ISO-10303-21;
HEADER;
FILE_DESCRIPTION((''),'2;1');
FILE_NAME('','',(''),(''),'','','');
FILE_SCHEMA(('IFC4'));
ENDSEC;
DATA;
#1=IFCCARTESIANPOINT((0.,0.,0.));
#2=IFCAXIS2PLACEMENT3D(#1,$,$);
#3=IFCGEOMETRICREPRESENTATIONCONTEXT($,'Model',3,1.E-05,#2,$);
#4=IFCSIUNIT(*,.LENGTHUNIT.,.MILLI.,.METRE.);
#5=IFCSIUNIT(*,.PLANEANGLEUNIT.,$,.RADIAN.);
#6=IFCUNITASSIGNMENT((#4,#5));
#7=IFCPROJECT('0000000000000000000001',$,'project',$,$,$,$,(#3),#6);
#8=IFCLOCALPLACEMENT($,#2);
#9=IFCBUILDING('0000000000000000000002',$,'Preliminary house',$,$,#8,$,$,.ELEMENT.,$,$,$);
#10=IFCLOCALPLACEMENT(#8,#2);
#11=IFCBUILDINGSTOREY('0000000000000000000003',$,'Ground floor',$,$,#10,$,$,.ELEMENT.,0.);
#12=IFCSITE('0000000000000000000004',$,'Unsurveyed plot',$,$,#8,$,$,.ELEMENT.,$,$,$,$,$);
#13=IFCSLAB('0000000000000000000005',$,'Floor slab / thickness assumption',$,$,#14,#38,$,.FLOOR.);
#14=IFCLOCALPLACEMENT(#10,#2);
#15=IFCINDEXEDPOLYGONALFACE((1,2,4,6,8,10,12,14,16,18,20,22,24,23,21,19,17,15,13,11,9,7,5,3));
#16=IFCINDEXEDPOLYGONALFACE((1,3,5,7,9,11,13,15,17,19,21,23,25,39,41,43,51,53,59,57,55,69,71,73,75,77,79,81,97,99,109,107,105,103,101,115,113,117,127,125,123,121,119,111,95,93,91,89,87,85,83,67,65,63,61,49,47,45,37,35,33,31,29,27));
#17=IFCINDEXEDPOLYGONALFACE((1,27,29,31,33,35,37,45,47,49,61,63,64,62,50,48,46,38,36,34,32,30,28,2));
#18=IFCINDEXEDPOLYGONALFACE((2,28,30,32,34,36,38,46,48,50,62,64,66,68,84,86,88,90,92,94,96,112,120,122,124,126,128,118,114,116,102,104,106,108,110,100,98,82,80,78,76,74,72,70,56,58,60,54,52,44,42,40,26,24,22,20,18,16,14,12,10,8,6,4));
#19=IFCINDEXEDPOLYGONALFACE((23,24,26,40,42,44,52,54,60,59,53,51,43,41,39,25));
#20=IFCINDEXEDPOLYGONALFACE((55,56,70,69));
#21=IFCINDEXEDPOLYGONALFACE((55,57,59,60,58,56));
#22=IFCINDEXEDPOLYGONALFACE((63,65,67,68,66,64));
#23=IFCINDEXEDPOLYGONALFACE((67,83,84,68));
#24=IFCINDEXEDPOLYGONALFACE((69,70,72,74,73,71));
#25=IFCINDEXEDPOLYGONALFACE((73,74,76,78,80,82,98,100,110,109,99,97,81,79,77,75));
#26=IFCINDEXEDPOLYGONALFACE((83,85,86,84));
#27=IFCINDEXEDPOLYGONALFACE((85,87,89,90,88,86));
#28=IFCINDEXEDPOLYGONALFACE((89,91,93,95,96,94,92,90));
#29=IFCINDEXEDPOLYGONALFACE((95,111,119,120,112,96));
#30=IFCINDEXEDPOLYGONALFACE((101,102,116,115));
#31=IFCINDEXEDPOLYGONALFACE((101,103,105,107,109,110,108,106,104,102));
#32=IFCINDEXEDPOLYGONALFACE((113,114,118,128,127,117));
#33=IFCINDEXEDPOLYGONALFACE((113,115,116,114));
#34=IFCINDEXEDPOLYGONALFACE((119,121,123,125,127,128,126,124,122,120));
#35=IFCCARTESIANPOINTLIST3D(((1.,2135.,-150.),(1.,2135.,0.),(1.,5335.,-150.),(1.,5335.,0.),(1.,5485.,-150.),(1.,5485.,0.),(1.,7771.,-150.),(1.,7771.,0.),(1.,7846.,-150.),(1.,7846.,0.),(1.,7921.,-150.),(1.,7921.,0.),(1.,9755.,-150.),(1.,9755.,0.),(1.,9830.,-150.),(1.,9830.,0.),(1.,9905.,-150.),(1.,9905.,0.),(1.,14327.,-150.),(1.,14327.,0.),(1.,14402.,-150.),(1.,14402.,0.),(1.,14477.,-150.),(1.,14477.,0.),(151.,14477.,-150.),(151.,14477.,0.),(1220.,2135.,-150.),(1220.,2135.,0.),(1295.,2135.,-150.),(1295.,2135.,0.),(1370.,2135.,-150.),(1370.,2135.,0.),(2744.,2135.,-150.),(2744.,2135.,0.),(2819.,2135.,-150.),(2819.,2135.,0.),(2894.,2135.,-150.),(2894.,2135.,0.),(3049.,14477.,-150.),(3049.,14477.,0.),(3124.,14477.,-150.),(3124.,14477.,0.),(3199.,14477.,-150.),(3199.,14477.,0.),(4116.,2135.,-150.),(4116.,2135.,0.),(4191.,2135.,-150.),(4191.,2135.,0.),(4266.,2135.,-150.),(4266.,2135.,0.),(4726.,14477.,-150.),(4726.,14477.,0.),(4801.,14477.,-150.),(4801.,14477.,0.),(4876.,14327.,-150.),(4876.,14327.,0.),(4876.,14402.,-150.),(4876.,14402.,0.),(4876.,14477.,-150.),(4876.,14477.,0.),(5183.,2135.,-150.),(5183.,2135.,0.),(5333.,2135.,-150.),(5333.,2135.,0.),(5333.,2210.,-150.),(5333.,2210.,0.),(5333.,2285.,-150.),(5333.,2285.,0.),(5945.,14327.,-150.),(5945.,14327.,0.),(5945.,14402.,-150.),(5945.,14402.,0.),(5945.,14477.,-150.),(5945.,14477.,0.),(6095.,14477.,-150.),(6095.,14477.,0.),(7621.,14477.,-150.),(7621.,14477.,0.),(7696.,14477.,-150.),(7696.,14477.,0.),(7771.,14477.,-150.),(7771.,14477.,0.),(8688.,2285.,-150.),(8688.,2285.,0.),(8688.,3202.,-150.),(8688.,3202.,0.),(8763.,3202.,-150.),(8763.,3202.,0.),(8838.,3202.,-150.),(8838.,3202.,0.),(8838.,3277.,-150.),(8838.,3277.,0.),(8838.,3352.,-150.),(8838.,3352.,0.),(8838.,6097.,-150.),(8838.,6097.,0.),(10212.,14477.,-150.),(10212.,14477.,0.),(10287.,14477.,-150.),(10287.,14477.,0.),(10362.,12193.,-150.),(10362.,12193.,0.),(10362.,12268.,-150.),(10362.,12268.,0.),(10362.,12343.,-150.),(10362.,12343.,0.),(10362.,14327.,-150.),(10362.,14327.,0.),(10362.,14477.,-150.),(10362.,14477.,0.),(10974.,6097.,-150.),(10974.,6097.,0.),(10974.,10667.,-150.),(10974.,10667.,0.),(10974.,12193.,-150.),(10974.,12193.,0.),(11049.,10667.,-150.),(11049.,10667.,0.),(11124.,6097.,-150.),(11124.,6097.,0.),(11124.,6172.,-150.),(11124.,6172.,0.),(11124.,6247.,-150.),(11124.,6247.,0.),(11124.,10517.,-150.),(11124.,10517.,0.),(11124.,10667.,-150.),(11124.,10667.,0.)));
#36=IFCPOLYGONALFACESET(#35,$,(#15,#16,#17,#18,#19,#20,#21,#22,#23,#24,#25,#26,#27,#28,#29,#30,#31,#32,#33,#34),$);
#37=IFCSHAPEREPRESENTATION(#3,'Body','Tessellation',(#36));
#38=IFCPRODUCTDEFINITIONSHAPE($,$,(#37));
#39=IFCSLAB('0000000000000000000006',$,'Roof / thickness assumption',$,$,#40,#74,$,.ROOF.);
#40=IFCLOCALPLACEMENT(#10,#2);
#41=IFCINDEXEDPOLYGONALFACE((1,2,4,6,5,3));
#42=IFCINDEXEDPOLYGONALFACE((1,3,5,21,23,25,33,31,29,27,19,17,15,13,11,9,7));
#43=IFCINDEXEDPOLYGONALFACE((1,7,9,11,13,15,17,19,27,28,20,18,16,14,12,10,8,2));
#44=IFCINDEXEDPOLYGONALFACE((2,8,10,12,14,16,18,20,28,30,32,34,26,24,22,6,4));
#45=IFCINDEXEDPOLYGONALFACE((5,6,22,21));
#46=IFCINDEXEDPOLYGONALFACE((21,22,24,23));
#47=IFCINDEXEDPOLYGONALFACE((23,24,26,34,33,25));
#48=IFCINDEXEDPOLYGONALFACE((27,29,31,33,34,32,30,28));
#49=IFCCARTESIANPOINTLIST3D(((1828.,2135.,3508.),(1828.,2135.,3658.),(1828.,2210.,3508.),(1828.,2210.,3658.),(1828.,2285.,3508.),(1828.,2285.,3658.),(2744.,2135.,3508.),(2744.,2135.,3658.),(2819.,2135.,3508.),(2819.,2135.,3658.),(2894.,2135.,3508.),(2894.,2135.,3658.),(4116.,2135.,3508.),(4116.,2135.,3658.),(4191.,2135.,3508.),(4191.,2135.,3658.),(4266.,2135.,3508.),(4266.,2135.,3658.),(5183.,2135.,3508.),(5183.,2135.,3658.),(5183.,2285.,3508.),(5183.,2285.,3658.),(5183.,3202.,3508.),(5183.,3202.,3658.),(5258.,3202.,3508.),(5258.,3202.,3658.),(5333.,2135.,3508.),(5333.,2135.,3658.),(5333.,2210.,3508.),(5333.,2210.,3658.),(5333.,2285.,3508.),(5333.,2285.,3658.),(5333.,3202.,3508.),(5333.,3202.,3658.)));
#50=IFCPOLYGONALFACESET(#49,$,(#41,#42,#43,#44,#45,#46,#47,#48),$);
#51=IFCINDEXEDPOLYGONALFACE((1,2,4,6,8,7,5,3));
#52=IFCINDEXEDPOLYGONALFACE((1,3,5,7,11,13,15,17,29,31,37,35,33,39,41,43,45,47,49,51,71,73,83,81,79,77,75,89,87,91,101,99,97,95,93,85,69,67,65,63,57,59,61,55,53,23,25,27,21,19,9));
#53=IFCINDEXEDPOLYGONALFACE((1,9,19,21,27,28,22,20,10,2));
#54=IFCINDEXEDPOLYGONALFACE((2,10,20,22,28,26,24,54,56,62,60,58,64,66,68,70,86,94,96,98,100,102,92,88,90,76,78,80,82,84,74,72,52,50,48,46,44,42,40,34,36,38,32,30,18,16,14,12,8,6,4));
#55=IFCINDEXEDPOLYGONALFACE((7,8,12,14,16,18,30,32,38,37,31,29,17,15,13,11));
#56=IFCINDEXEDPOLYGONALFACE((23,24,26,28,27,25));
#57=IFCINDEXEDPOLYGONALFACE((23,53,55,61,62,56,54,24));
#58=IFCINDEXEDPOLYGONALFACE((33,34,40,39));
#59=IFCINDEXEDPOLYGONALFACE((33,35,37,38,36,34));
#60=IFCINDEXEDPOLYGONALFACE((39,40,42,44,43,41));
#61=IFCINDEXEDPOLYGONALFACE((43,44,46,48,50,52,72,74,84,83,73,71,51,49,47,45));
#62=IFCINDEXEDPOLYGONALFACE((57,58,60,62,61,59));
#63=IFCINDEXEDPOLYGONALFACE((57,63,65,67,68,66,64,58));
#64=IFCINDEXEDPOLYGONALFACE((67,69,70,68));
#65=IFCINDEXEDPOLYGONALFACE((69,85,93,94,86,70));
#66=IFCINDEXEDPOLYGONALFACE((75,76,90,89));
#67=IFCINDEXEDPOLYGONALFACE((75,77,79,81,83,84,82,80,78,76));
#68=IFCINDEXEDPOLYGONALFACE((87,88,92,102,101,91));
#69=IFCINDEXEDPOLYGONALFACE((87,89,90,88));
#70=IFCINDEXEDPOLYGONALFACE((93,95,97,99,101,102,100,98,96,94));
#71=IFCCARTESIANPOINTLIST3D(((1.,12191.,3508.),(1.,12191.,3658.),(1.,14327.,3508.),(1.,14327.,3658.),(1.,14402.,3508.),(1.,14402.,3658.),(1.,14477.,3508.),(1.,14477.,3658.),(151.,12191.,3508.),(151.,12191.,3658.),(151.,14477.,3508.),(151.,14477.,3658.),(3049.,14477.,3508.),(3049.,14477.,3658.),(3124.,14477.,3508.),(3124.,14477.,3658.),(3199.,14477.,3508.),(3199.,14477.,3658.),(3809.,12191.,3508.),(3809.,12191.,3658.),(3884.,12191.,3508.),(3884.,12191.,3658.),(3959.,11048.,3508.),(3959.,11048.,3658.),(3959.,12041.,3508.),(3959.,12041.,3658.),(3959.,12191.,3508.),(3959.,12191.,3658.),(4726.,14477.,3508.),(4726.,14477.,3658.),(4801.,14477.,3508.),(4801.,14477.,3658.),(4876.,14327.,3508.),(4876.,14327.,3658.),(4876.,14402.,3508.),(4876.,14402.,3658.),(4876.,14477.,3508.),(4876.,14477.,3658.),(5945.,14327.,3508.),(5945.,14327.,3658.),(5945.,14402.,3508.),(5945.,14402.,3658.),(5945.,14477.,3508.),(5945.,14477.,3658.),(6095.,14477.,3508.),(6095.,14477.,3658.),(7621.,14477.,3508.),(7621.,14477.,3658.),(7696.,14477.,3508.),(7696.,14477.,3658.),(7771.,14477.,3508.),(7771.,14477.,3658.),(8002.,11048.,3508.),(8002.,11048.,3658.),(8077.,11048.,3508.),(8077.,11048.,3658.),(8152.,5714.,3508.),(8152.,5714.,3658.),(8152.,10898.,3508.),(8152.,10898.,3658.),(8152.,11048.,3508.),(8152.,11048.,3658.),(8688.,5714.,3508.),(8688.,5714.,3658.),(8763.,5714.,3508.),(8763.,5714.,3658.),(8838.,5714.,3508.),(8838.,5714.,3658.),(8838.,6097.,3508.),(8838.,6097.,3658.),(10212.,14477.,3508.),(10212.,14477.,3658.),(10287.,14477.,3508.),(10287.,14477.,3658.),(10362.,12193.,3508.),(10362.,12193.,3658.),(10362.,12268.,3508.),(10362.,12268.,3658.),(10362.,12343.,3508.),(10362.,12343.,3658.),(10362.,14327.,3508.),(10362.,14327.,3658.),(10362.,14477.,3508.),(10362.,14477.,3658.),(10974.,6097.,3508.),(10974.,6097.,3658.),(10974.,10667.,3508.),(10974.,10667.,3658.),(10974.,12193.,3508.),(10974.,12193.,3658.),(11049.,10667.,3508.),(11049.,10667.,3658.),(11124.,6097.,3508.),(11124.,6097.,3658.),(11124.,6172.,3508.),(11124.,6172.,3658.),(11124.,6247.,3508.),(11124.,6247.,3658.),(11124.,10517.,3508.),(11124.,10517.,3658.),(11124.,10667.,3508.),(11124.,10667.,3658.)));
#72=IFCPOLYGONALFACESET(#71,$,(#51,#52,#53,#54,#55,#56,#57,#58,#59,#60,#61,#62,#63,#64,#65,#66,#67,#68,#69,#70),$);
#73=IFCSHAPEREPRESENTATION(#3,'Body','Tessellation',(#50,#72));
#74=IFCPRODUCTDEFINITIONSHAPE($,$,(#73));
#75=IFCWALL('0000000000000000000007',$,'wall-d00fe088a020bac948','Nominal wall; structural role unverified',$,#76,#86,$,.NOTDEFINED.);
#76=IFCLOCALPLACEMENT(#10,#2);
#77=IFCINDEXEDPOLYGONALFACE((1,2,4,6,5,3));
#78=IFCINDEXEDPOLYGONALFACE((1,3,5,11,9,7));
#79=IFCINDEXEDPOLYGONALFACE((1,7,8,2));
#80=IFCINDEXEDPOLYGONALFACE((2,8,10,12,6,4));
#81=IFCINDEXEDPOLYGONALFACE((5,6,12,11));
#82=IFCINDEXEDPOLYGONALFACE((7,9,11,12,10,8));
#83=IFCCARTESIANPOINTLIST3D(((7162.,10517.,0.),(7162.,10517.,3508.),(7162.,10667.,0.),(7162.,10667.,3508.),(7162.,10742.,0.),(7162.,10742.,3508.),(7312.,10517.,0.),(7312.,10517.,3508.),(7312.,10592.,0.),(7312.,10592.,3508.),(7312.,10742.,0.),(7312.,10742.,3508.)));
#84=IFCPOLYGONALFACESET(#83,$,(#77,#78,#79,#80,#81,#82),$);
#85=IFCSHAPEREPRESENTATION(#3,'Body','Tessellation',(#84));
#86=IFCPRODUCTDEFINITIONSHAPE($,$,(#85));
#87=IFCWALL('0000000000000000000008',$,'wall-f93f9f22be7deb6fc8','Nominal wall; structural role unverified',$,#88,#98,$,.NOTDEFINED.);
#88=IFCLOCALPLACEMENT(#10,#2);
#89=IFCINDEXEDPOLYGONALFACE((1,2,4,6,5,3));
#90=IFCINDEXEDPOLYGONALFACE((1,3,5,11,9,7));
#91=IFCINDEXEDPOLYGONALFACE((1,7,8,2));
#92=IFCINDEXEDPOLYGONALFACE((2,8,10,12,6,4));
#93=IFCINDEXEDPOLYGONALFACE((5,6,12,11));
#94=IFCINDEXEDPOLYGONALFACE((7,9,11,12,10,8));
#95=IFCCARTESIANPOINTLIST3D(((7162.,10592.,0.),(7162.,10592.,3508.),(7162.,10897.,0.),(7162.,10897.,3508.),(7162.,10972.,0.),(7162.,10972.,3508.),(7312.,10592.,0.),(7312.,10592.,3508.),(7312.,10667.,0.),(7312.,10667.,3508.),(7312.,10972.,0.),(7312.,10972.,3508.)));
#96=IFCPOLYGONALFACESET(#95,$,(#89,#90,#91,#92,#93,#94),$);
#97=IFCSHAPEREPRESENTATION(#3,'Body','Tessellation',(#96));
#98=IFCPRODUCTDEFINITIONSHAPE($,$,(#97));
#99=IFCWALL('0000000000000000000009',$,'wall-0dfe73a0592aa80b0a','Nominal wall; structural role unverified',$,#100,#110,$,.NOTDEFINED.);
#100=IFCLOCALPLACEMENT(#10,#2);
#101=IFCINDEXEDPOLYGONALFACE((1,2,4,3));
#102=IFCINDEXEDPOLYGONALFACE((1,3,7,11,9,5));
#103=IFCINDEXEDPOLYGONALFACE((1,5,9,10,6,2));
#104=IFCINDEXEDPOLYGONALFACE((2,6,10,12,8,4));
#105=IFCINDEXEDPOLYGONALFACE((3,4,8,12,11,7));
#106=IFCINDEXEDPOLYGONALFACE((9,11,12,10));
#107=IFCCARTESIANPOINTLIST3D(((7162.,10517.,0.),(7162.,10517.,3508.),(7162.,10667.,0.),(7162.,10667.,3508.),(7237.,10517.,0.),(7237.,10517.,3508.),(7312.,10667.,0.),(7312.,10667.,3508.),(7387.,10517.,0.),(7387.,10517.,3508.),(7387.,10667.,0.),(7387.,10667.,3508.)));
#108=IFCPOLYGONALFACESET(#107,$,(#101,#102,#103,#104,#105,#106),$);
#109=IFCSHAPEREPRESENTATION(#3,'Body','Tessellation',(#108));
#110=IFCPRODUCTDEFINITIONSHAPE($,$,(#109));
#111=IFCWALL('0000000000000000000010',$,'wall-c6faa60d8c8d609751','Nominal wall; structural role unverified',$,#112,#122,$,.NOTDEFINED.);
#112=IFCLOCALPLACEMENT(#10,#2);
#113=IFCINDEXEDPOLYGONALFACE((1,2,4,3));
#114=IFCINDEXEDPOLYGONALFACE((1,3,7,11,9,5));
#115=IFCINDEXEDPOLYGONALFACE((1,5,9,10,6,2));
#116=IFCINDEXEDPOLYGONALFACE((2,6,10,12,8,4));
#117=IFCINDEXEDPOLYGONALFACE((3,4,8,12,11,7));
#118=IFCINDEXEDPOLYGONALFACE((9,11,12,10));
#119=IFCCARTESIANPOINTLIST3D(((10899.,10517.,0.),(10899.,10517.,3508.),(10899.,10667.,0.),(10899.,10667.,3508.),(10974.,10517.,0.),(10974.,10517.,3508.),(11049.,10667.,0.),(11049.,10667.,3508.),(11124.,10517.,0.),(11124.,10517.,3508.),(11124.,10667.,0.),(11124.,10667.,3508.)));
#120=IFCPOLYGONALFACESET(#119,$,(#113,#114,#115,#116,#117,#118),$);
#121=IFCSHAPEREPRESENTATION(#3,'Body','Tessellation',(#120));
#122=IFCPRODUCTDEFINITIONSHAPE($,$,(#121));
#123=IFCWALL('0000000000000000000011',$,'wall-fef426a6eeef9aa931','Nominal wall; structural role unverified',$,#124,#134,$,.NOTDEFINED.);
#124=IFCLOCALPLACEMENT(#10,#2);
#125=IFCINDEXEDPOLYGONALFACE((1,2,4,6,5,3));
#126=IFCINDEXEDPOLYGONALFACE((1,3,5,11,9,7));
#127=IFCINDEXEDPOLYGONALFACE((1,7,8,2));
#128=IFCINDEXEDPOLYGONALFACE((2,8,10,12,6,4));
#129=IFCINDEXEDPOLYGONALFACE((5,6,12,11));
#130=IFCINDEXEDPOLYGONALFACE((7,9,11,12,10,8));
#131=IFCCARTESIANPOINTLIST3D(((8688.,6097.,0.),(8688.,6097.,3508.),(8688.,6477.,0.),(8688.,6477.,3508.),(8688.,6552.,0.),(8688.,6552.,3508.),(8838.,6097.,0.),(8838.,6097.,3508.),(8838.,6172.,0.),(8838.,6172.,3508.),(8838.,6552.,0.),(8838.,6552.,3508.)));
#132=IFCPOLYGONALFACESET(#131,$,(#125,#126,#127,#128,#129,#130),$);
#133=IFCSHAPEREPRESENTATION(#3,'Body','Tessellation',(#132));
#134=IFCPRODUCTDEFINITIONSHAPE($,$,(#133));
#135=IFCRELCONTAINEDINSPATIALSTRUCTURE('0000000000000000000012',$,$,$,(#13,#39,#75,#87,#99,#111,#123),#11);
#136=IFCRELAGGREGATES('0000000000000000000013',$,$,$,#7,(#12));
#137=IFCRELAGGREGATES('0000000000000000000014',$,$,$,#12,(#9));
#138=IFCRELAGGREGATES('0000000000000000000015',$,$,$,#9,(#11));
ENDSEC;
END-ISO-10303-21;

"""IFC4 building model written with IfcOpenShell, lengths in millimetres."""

from ifc_helpers import new_model, si_unit, frame, origin, place, context, project, spatial, polyline, outline, extrude, element, save


model = new_model("IFC4")

# Units and contexts
model_context = context("Model", 3, precision=1e-05, world=origin())
ifc_project = project(units=[si_unit("LENGTHUNIT", "METRE", prefix="MILLI"), si_unit("PLANEANGLEUNIT", "RADIAN")], contexts=[model_context])

# Site, building, storey
placement_1 = place(None, origin())
site = spatial("IfcSite", under=ifc_project, at=placement_1, Name="Unsurveyed plot", CompositionType="ELEMENT")
building = spatial("IfcBuilding", under=site, at=placement_1, Name="Preliminary house", CompositionType="ELEMENT")
placement_2 = place(placement_1, origin())
storey = spatial("IfcBuildingStorey", under=building, at=placement_2, Name="Ground floor", CompositionType="ELEMENT", Elevation=0.0)

# Slabs
element("IfcSlab", 1, at=placement_2, inside=storey, Name="Floor slab / thickness assumption", PredefinedType="FLOOR", context=model_context, shape_type="SweptSolid", body=[
    extrude(outline(polyline([(1370.0, 2135.0), (1295.0, 2135.0), (1220.0, 2135.0), (1.0, 2135.0), (1.0, 5335.0), (1.0, 5485.0), (1.0, 7771.0), (1.0, 7846.0), (1.0, 7921.0), (1.0, 9755.0), (1.0, 9830.0), (1.0, 9905.0), (1.0, 14327.0), (1.0, 14402.0), (1.0, 14477.0), (151.0, 14477.0), (3049.0, 14477.0), (3124.0, 14477.0), (3199.0, 14477.0), (4726.0, 14477.0), (4801.0, 14477.0), (4876.0, 14477.0), (4876.0, 14402.0), (4876.0, 14327.0), (5945.0, 14327.0), (5945.0, 14402.0), (5945.0, 14477.0), (6095.0, 14477.0), (7621.0, 14477.0), (7696.0, 14477.0), (7771.0, 14477.0), (10212.0, 14477.0), (10287.0, 14477.0), (10362.0, 14477.0), (10362.0, 14327.0), (10362.0, 12343.0), (10362.0, 12268.0), (10362.0, 12193.0), (10974.0, 12193.0), (10974.0, 10667.0), (11049.0, 10667.0), (11124.0, 10667.0), (11124.0, 10517.0), (11124.0, 6247.0), (11124.0, 6172.0), (11124.0, 6097.0), (10974.0, 6097.0), (8838.0, 6097.0), (8838.0, 3352.0), (8838.0, 3277.0), (8838.0, 3202.0), (8763.0, 3202.0), (8688.0, 3202.0), (8688.0, 2285.0), (5333.0, 2285.0), (5333.0, 2210.0), (5333.0, 2135.0), (5183.0, 2135.0), (4266.0, 2135.0), (4191.0, 2135.0), (4116.0, 2135.0), (2894.0, 2135.0), (2819.0, 2135.0), (2744.0, 2135.0), (1370.0, 2135.0)])), frame((0.0, 0.0, -150.0)), (0.0, 0.0, 1.0), 150.0),
])
element("IfcSlab", 2, at=placement_2, inside=storey, Name="Roof / thickness assumption", PredefinedType="ROOF", context=model_context, shape_type="SweptSolid", body=[
    extrude(outline(polyline([(5333.0, 2210.0), (5333.0, 2135.0), (5183.0, 2135.0), (4266.0, 2135.0), (4191.0, 2135.0), (4116.0, 2135.0), (2894.0, 2135.0), (2819.0, 2135.0), (2744.0, 2135.0), (1828.0, 2135.0), (1828.0, 2210.0), (1828.0, 2285.0), (5183.0, 2285.0), (5183.0, 3202.0), (5258.0, 3202.0), (5333.0, 3202.0), (5333.0, 2285.0), (5333.0, 2210.0)])), frame((0.0, 0.0, 3508.0)), (0.0, 0.0, 1.0), 150.0),
    extrude(outline(polyline([(1.0, 14402.0), (1.0, 14477.0), (151.0, 14477.0), (3049.0, 14477.0), (3124.0, 14477.0), (3199.0, 14477.0), (4726.0, 14477.0), (4801.0, 14477.0), (4876.0, 14477.0), (4876.0, 14402.0), (4876.0, 14327.0), (5945.0, 14327.0), (5945.0, 14402.0), (5945.0, 14477.0), (6095.0, 14477.0), (7621.0, 14477.0), (7696.0, 14477.0), (7771.0, 14477.0), (10212.0, 14477.0), (10287.0, 14477.0), (10362.0, 14477.0), (10362.0, 14327.0), (10362.0, 12343.0), (10362.0, 12268.0), (10362.0, 12193.0), (10974.0, 12193.0), (10974.0, 10667.0), (11049.0, 10667.0), (11124.0, 10667.0), (11124.0, 10517.0), (11124.0, 6247.0), (11124.0, 6172.0), (11124.0, 6097.0), (10974.0, 6097.0), (8838.0, 6097.0), (8838.0, 5714.0), (8763.0, 5714.0), (8688.0, 5714.0), (8152.0, 5714.0), (8152.0, 10898.0), (8152.0, 11048.0), (8077.0, 11048.0), (8002.0, 11048.0), (3959.0, 11048.0), (3959.0, 12041.0), (3959.0, 12191.0), (3884.0, 12191.0), (3809.0, 12191.0), (151.0, 12191.0), (1.0, 12191.0), (1.0, 14327.0), (1.0, 14402.0)])), frame((0.0, 0.0, 3508.0)), (0.0, 0.0, 1.0), 150.0),
])

# Walls
element("IfcWall", 3, at=placement_2, inside=storey, Name="wall-d00fe088a020bac948", Description="Nominal wall; structural role unverified", PredefinedType="NOTDEFINED", context=model_context, shape_type="SweptSolid", body=[
    extrude(outline(polyline([(7162.0, 10667.0), (7162.0, 10742.0), (7312.0, 10742.0), (7312.0, 10592.0), (7312.0, 10517.0), (7162.0, 10517.0), (7162.0, 10667.0)])), origin(), (0.0, 0.0, 1.0), 3508.0),
])
element("IfcWall", 4, at=placement_2, inside=storey, Name="wall-f93f9f22be7deb6fc8", Description="Nominal wall; structural role unverified", PredefinedType="NOTDEFINED", context=model_context, shape_type="SweptSolid", body=[
    extrude(outline(polyline([(7162.0, 10897.0), (7162.0, 10972.0), (7312.0, 10972.0), (7312.0, 10667.0), (7312.0, 10592.0), (7162.0, 10592.0), (7162.0, 10897.0)])), origin(), (0.0, 0.0, 1.0), 3508.0),
])
element("IfcWall", 5, at=placement_2, inside=storey, Name="wall-0dfe73a0592aa80b0a", Description="Nominal wall; structural role unverified", PredefinedType="NOTDEFINED", context=model_context, shape_type="SweptSolid", body=[
    extrude(outline(polyline([(7312.0, 10667.0), (7387.0, 10667.0), (7387.0, 10517.0), (7237.0, 10517.0), (7162.0, 10517.0), (7162.0, 10667.0), (7312.0, 10667.0)])), origin(), (0.0, 0.0, 1.0), 3508.0),
])

# Wall
element("IfcWall", 6, at=placement_2, inside=storey, Name="wall-c6faa60d8c8d609751", Description="Nominal wall; structural role unverified", PredefinedType="NOTDEFINED", context=model_context, shape_type="SweptSolid", body=[
    extrude(outline(polyline([(11049.0, 10667.0), (11124.0, 10667.0), (11124.0, 10517.0), (10974.0, 10517.0), (10899.0, 10517.0), (10899.0, 10667.0), (11049.0, 10667.0)])), origin(), (0.0, 0.0, 1.0), 3508.0),
])

# Wall
element("IfcWall", 7, at=placement_2, inside=storey, Name="wall-fef426a6eeef9aa931", Description="Nominal wall; structural role unverified", PredefinedType="NOTDEFINED", context=model_context, shape_type="SweptSolid", body=[
    extrude(outline(polyline([(8688.0, 6477.0), (8688.0, 6552.0), (8838.0, 6552.0), (8838.0, 6172.0), (8838.0, 6097.0), (8688.0, 6097.0), (8688.0, 6477.0)])), origin(), (0.0, 0.0, 1.0), 3508.0),
])

save(model, "model.ifc")
